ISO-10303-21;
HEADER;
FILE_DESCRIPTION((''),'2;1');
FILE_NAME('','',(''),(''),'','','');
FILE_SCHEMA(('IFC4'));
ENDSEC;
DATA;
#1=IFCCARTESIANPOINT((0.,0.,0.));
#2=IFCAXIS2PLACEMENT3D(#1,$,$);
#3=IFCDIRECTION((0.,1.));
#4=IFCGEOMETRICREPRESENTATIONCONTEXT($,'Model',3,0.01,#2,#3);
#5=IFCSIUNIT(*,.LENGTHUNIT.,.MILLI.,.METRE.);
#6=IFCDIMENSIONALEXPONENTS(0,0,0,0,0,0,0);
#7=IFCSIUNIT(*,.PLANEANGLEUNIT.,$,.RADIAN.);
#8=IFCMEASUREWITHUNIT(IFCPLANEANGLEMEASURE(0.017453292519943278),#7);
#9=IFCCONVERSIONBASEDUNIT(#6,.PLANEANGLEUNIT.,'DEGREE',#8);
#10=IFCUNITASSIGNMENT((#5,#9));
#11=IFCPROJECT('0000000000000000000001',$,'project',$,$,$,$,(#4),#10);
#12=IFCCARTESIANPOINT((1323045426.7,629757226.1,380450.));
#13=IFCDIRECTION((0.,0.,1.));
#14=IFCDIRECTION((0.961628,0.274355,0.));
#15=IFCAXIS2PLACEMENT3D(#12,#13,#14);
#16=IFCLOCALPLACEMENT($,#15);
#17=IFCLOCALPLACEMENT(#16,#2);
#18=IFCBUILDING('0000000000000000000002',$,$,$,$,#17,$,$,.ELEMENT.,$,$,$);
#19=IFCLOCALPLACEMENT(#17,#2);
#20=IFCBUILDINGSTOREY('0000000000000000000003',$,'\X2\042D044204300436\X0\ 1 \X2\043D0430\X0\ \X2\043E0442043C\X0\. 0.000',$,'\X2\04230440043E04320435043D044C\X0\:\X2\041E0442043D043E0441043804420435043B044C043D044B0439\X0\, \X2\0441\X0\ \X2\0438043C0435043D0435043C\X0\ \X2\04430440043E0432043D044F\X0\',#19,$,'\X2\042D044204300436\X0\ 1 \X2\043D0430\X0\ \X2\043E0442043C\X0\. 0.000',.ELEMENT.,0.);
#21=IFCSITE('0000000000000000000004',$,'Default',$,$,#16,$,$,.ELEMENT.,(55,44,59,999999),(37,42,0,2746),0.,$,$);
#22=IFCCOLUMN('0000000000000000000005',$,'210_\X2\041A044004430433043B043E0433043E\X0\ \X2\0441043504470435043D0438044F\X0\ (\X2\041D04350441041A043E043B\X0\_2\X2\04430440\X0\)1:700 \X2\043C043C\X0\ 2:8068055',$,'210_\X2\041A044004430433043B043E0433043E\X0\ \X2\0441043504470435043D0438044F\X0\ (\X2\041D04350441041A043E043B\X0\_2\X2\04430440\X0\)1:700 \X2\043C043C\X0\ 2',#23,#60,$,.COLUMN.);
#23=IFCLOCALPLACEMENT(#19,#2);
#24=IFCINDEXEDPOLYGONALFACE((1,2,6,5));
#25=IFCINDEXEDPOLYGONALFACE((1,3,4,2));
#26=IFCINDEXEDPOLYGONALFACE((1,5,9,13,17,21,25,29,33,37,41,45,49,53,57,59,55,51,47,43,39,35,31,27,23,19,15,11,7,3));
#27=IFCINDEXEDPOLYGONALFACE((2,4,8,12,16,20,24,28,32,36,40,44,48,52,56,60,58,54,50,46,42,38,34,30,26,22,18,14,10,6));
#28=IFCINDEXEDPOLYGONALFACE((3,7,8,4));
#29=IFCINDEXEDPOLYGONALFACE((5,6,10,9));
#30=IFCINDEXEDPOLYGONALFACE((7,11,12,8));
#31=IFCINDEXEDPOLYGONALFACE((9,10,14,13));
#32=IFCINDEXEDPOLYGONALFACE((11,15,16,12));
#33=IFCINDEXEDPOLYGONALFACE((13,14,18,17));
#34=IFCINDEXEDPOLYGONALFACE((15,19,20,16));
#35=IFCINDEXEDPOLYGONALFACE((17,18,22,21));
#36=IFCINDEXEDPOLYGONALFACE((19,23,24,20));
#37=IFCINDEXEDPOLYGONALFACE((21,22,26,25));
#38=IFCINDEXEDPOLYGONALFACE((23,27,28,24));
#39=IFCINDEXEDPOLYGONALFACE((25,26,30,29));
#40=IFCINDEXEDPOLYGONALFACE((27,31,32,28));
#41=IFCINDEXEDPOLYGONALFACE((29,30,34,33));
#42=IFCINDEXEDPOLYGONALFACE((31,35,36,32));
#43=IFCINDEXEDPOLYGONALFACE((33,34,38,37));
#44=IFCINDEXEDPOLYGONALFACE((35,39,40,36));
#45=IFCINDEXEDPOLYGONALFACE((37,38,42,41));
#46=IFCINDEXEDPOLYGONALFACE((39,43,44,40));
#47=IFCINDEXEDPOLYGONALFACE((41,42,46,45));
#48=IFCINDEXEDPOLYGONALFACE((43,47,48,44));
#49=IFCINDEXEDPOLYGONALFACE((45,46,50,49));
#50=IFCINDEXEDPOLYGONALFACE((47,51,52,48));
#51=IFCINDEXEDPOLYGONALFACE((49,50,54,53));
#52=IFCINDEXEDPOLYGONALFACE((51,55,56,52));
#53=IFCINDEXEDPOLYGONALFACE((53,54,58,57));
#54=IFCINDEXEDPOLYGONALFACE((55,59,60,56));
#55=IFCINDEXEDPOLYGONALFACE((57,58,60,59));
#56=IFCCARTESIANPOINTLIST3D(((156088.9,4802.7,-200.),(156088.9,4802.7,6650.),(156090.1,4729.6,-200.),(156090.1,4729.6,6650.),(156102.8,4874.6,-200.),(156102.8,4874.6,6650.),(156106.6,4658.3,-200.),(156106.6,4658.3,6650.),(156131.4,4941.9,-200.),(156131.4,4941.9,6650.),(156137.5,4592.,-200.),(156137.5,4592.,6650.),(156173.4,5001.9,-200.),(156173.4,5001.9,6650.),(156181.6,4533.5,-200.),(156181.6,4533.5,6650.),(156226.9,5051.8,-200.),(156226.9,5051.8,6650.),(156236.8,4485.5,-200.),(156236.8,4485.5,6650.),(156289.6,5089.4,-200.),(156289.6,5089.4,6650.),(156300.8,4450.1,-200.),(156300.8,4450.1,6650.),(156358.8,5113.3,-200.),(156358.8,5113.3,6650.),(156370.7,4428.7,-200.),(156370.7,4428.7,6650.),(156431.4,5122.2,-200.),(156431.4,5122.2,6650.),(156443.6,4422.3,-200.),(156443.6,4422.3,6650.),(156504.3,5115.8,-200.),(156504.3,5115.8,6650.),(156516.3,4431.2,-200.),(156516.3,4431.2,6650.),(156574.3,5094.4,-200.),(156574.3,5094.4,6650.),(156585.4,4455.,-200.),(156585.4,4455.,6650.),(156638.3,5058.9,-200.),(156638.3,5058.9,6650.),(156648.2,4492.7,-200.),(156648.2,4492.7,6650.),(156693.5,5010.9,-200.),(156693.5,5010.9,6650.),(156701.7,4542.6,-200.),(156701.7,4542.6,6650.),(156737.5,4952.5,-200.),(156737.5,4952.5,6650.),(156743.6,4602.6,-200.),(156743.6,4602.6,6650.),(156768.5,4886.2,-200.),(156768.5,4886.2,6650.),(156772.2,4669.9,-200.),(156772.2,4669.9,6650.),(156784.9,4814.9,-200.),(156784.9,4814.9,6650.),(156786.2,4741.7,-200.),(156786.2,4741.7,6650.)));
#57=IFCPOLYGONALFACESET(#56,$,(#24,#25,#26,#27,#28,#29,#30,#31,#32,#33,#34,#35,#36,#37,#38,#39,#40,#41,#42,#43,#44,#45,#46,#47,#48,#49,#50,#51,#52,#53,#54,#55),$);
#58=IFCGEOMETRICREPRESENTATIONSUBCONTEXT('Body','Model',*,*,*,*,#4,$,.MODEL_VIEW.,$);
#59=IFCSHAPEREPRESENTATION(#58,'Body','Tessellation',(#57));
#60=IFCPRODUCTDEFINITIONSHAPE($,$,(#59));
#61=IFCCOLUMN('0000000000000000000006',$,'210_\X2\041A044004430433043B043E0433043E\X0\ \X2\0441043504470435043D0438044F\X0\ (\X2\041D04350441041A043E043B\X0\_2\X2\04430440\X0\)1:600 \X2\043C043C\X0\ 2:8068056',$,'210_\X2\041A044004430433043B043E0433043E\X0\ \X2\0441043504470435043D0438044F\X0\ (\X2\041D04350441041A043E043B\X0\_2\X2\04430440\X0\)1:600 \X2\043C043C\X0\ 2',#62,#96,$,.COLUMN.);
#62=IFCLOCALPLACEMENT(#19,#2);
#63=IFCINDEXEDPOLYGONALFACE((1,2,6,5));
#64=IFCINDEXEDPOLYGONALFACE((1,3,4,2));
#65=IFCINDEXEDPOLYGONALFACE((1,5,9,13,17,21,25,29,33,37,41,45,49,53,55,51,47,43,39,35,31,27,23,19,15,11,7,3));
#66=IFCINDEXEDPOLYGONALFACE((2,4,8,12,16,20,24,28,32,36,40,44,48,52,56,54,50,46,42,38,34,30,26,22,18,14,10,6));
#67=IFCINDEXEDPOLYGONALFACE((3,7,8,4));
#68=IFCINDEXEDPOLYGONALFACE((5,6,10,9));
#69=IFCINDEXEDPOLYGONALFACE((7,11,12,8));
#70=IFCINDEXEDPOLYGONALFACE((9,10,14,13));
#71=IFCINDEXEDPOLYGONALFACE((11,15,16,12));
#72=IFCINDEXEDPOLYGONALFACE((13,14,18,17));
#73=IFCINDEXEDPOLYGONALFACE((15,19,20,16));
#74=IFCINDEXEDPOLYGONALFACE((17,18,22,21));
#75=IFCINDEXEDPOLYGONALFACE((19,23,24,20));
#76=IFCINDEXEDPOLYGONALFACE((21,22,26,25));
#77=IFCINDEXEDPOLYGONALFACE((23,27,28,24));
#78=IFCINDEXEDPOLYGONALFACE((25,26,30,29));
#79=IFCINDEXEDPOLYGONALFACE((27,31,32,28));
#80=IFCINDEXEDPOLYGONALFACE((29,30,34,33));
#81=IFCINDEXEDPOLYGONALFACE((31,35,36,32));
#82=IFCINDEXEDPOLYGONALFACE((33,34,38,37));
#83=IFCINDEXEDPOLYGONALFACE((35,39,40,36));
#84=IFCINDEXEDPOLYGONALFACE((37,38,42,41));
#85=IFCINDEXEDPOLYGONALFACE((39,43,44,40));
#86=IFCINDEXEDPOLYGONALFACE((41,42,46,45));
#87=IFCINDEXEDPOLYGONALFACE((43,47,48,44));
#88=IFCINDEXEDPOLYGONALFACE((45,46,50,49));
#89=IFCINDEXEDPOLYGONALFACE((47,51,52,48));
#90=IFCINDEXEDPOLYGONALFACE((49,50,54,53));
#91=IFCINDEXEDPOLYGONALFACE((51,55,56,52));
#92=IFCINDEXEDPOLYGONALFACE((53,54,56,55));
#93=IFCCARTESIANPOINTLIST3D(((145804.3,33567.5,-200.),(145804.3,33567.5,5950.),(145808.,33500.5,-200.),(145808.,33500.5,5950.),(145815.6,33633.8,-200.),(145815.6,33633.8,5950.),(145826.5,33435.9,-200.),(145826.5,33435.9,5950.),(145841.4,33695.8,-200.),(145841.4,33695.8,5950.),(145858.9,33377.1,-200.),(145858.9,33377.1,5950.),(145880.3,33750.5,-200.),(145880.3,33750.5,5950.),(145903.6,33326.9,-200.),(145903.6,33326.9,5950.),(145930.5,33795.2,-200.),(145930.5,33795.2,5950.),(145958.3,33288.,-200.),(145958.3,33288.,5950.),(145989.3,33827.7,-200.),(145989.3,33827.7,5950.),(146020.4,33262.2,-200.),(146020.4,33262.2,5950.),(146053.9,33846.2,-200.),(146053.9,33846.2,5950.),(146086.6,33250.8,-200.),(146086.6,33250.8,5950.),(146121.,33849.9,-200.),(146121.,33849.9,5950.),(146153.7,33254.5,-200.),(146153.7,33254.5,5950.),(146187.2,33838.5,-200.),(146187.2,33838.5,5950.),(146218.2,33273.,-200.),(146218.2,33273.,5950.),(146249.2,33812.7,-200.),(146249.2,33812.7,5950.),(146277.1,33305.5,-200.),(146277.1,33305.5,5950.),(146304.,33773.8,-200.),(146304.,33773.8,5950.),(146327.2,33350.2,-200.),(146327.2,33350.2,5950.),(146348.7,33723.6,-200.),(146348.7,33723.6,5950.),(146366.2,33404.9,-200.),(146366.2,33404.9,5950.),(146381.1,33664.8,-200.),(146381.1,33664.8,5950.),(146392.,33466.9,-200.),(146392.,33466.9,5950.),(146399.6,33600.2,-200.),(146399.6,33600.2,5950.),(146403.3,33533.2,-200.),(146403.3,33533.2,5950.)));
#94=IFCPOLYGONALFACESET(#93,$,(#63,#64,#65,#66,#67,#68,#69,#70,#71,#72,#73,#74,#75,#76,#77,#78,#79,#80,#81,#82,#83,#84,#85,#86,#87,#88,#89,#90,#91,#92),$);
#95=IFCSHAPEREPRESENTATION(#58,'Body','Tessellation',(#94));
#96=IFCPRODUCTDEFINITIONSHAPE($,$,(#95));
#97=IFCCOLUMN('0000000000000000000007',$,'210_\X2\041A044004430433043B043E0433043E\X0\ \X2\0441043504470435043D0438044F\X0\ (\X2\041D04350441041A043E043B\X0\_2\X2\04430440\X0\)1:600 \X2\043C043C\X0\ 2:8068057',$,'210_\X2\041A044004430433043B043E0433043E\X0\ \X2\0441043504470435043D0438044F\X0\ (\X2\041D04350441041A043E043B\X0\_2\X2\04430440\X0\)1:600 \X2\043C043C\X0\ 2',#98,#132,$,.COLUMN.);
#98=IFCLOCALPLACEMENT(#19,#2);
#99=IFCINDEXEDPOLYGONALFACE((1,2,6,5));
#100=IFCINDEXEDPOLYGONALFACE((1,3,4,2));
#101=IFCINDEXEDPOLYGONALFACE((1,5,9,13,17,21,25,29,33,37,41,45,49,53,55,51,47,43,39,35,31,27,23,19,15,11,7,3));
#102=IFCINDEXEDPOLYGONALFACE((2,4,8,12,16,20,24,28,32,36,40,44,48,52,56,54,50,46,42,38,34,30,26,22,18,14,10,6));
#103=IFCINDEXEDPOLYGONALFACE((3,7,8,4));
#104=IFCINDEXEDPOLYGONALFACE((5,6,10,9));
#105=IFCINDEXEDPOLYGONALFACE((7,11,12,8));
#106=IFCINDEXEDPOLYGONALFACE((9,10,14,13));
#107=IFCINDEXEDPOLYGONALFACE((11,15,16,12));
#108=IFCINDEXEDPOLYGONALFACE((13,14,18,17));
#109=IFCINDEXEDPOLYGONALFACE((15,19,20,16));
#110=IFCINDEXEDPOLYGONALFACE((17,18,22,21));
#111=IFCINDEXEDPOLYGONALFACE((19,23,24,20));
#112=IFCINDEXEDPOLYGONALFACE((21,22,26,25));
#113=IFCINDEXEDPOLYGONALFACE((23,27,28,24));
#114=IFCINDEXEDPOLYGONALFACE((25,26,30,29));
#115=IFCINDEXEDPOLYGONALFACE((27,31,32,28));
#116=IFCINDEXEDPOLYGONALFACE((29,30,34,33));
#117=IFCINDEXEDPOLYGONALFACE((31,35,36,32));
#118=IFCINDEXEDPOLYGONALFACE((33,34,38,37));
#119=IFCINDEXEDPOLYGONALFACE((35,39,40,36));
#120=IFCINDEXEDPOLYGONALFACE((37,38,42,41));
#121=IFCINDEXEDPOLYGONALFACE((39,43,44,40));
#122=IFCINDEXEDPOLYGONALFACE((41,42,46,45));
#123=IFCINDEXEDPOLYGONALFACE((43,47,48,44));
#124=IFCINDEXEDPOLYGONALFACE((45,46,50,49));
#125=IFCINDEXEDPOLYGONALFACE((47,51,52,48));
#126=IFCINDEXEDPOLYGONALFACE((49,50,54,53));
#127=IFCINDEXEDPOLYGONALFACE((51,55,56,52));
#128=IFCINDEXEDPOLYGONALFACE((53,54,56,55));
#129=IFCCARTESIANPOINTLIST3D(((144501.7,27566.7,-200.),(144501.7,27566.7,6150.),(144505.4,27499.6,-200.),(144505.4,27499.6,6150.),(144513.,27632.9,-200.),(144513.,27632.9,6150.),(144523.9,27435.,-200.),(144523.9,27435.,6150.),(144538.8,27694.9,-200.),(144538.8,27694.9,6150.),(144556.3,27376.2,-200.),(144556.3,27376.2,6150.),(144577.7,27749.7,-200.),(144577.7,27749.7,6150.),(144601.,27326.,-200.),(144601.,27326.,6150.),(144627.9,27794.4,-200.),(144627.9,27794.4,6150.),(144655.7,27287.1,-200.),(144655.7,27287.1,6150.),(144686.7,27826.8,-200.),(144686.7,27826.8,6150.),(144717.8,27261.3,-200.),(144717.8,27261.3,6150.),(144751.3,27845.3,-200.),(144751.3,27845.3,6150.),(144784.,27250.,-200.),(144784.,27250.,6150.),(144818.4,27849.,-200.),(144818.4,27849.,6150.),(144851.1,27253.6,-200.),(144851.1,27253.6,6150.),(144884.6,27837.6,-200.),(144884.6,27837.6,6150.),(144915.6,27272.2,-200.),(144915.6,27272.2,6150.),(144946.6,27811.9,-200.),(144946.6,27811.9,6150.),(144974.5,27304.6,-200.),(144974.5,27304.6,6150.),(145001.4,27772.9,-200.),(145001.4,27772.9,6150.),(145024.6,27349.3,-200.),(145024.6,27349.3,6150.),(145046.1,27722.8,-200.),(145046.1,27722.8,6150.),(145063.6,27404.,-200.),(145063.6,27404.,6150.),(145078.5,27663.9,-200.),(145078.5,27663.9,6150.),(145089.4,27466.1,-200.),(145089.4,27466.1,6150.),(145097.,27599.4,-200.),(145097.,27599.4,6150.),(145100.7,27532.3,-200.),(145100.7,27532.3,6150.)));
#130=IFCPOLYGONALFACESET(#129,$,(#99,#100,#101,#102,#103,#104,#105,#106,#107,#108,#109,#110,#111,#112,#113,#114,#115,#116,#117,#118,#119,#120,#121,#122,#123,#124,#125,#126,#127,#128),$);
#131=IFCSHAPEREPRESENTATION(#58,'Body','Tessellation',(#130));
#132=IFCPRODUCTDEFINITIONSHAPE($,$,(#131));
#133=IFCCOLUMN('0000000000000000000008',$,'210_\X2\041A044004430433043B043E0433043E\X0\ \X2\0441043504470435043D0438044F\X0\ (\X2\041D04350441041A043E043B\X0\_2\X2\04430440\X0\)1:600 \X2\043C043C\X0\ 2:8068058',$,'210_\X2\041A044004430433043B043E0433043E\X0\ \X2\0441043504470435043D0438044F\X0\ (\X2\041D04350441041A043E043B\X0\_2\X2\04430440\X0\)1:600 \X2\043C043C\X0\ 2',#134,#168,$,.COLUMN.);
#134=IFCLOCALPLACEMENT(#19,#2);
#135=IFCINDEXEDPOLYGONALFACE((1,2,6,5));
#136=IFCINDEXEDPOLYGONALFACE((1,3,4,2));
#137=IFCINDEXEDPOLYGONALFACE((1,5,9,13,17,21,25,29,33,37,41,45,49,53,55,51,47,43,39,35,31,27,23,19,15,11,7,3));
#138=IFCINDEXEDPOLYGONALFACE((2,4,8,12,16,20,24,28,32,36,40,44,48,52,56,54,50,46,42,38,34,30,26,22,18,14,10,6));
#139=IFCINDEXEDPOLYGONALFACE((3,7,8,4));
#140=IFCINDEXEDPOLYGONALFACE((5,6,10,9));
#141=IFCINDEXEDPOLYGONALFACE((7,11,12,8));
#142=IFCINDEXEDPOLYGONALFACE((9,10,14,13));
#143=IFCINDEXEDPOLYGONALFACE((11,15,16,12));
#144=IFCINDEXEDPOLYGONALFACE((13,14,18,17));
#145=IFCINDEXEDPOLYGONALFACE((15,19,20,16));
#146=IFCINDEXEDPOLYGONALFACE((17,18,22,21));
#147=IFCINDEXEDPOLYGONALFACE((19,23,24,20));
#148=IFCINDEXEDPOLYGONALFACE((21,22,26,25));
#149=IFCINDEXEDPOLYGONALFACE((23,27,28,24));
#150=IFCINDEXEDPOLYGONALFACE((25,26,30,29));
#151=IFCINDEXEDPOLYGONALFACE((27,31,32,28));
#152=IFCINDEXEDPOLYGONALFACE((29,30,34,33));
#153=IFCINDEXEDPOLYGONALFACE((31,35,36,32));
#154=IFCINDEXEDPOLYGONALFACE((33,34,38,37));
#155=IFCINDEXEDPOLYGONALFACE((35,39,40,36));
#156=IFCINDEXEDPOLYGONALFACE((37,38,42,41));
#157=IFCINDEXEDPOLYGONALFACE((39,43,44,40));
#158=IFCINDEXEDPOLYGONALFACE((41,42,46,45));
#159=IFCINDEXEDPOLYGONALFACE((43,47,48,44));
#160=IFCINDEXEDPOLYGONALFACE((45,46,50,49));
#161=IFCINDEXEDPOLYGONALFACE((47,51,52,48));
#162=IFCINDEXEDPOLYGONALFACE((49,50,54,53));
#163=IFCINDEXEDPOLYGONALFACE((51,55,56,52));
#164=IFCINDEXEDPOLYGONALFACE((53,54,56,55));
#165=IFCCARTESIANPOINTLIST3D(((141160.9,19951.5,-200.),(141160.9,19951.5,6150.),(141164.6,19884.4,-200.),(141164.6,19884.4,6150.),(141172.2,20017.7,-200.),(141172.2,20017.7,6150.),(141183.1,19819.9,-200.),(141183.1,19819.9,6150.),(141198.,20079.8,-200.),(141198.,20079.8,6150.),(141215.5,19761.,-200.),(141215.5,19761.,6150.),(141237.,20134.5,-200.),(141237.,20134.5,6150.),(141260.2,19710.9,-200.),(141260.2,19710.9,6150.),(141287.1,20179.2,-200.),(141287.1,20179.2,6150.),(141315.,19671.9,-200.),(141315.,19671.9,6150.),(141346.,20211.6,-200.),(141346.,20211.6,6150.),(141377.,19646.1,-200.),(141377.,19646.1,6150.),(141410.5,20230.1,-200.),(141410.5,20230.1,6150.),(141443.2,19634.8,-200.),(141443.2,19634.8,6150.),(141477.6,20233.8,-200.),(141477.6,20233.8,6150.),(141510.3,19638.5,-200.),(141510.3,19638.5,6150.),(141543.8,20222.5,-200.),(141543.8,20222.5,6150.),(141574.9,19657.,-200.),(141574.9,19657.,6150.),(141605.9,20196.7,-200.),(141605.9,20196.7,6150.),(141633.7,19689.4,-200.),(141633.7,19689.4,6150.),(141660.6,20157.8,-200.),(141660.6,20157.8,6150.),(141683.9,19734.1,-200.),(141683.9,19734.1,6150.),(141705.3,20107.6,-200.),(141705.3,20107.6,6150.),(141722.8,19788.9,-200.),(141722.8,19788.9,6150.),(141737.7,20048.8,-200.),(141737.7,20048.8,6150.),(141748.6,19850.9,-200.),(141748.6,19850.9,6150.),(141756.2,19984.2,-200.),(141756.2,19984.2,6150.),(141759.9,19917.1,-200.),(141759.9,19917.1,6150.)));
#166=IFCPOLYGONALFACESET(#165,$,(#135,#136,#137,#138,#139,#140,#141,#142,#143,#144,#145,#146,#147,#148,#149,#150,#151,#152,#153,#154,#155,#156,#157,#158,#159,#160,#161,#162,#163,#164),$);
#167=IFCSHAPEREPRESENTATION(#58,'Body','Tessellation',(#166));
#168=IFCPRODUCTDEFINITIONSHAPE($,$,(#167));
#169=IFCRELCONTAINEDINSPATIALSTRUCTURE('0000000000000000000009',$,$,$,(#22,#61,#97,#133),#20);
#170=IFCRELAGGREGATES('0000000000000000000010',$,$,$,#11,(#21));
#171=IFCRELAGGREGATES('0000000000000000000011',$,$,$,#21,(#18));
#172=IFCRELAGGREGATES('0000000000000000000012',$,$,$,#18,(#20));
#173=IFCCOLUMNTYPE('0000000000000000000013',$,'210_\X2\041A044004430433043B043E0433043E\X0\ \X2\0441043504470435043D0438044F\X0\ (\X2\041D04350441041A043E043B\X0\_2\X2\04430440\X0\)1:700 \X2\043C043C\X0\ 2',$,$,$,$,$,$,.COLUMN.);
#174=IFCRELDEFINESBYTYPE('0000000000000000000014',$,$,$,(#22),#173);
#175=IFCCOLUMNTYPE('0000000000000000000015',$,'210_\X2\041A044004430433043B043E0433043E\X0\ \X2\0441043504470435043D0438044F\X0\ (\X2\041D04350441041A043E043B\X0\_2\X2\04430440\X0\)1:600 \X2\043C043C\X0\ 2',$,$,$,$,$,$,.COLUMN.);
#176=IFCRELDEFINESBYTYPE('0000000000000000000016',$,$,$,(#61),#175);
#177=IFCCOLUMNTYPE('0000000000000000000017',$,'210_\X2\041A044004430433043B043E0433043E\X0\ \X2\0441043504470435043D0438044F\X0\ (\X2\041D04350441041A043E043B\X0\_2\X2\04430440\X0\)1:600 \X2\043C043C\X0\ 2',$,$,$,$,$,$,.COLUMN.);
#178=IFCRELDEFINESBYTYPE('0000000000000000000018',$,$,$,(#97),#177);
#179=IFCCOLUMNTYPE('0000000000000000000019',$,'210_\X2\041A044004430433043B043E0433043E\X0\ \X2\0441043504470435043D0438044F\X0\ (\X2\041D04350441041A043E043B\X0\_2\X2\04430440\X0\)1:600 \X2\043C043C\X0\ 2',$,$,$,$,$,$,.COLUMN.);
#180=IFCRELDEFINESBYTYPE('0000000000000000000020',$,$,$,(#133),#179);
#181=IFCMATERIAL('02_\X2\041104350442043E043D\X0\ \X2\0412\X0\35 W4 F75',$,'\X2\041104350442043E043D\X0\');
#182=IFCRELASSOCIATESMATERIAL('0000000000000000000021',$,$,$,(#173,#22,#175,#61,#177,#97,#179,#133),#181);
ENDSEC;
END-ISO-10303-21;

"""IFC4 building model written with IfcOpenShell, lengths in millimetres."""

from ifc_helpers import new_model, entity, si_unit, converted_unit, direction, frame, origin, place, context, subcontext, project, spatial, arc, indexed_curve, outline, extrude, source, transform, mapped, material, type_object, type_shapes, element, save


model = new_model("IFC4")

# Units and contexts
model_context = context("Model", 3, precision=0.01, world=origin(), true_north=direction((0.0, 1.0)))
body_context = subcontext(model_context, "Body", "Model", "MODEL_VIEW")
ifc_project = project(units=[si_unit("LENGTHUNIT", "METRE", prefix="MILLI"), converted_unit("PLANEANGLEUNIT", "DEGREE", entity("IfcPlaneAngleMeasure", 0.017453292519943278), si_unit("PLANEANGLEUNIT", "RADIAN"), dimensions=[0, 0, 0, 0, 0, 0, 0])], contexts=[model_context])

# Site, building, storey
site_placement = place(None, frame((1323045426.7, 629757226.1, 380450.0), z_axis=(0.0, 0.0, 1.0), x_axis=(0.961628, 0.274355, 0.0)))
site = spatial("IfcSite", under=ifc_project, at=site_placement, Name="Default", CompositionType="ELEMENT", RefLatitude=(55, 44, 59, 999999), RefLongitude=(37, 42, 0, 2746), RefElevation=0.0)
building_placement = place(site_placement, origin())
building = spatial("IfcBuilding", under=site, at=building_placement, CompositionType="ELEMENT")
storey_placement = place(building_placement, origin())
storey = spatial("IfcBuildingStorey", under=building, at=storey_placement, Name="Этаж 1 на отм. 0.000", ObjectType="Уровень:Относительный, с именем уровня", LongName="Этаж 1 на отм. 0.000", CompositionType="ELEMENT", Elevation=0.0)

# Columns
ifc_material = material(Name="02_Бетон В35 W4 F75", Category="Бетон")
column_type_1 = type_object("IfcColumnType", Name="210_Круглого сечения (НесКол_2ур)1:700 мм 2", PredefinedType="COLUMN", material=ifc_material)
shared_shape_1 = source(origin(), body_context, "Body", "SweptSolid", [
    extrude(outline(indexed_curve([(-350.0, 0.0), (0.0, -350.0), (350.0, 0.0), (0.0, 350.0)], segments=[arc(1, 2, 3), arc(3, 4, 1)], self_intersect=False)), frame((156437.5, 4772.2, -200.0), z_axis=(0.0, 0.0, 1.0), x_axis=(0.87462, -0.48481, 0.0)), (0.0, 0.0, 1.0), 6850.0),
])
type_shapes(column_type_1, [shared_shape_1])
column_1_placement = place(storey_placement, origin())
element("IfcColumn", 1, at=column_1_placement, inside=storey, type_object=column_type_1, material=ifc_material, Name="210_Круглого сечения (НесКол_2ур)1:700 мм 2:8068055", ObjectType="210_Круглого сечения (НесКол_2ур)1:700 мм 2", PredefinedType="COLUMN", context=body_context, shape_type="MappedRepresentation", body=[
    mapped(shared_shape_1, transform((0.0, 0.0, 0.0), scale=1.0)),
])
column_type_2 = type_object("IfcColumnType", Name="210_Круглого сечения (НесКол_2ур)1:600 мм 2", PredefinedType="COLUMN", material=ifc_material)
shared_shape_2 = source(origin(), body_context, "Body", "SweptSolid", [
    extrude(outline(indexed_curve([(-300.0, 0.0), (0.0, -300.0), (300.0, 0.0), (0.0, 300.0)], segments=[arc(1, 2, 3), arc(3, 4, 1)], self_intersect=False)), frame((146103.8, 33550.3, -200.0), z_axis=(0.0, 0.0, 1.0), x_axis=(0.87462, -0.48481, 0.0)), (0.0, 0.0, 1.0), 6150.0),
])
type_shapes(column_type_2, [shared_shape_2])
column_2_placement = place(storey_placement, origin())
element("IfcColumn", 2, at=column_2_placement, inside=storey, type_object=column_type_2, material=ifc_material, Name="210_Круглого сечения (НесКол_2ур)1:600 мм 2:8068056", ObjectType="210_Круглого сечения (НесКол_2ур)1:600 мм 2", PredefinedType="COLUMN", context=body_context, shape_type="MappedRepresentation", body=[
    mapped(shared_shape_2, transform((0.0, 0.0, 0.0), scale=1.0)),
])
column_type_3 = type_object("IfcColumnType", Name="210_Круглого сечения (НесКол_2ур)1:600 мм 2", PredefinedType="COLUMN", material=ifc_material)
shared_shape_3 = source(origin(), body_context, "Body", "SweptSolid", [
    extrude(outline(indexed_curve([(-300.0, 0.0), (0.0, -300.0), (300.0, 0.0), (0.0, 300.0)], segments=[arc(1, 2, 3), arc(3, 4, 1)], self_intersect=False)), frame((144801.2, 27549.5, -200.0), z_axis=(0.0, 0.0, 1.0), x_axis=(0.87462, -0.48481, 0.0)), (0.0, 0.0, 1.0), 6350.0),
])
type_shapes(column_type_3, [shared_shape_3])
column_3_placement = place(storey_placement, origin())
element("IfcColumn", 3, at=column_3_placement, inside=storey, type_object=column_type_3, material=ifc_material, Name="210_Круглого сечения (НесКол_2ур)1:600 мм 2:8068057", ObjectType="210_Круглого сечения (НесКол_2ур)1:600 мм 2", PredefinedType="COLUMN", context=body_context, shape_type="MappedRepresentation", body=[
    mapped(shared_shape_3, transform((0.0, 0.0, 0.0), scale=1.0)),
])
column_type_4 = type_object("IfcColumnType", Name="210_Круглого сечения (НесКол_2ур)1:600 мм 2", PredefinedType="COLUMN", material=ifc_material)
shared_shape_4 = source(origin(), body_context, "Body", "SweptSolid", [
    extrude(outline(indexed_curve([(-300.0, 0.0), (0.0, -300.0), (300.0, 0.0), (0.0, 300.0)], segments=[arc(1, 2, 3), arc(3, 4, 1)], self_intersect=False)), frame((141460.4, 19934.3, -200.0), z_axis=(0.0, 0.0, 1.0), x_axis=(0.87462, -0.48481, 0.0)), (0.0, 0.0, 1.0), 6350.0),
])
type_shapes(column_type_4, [shared_shape_4])
column_4_placement = place(storey_placement, origin())
element("IfcColumn", 4, at=column_4_placement, inside=storey, type_object=column_type_4, material=ifc_material, Name="210_Круглого сечения (НесКол_2ур)1:600 мм 2:8068058", ObjectType="210_Круглого сечения (НесКол_2ур)1:600 мм 2", PredefinedType="COLUMN", context=body_context, shape_type="MappedRepresentation", body=[
    mapped(shared_shape_4, transform((0.0, 0.0, 0.0), scale=1.0)),
])

save(model, "model.ifc")
